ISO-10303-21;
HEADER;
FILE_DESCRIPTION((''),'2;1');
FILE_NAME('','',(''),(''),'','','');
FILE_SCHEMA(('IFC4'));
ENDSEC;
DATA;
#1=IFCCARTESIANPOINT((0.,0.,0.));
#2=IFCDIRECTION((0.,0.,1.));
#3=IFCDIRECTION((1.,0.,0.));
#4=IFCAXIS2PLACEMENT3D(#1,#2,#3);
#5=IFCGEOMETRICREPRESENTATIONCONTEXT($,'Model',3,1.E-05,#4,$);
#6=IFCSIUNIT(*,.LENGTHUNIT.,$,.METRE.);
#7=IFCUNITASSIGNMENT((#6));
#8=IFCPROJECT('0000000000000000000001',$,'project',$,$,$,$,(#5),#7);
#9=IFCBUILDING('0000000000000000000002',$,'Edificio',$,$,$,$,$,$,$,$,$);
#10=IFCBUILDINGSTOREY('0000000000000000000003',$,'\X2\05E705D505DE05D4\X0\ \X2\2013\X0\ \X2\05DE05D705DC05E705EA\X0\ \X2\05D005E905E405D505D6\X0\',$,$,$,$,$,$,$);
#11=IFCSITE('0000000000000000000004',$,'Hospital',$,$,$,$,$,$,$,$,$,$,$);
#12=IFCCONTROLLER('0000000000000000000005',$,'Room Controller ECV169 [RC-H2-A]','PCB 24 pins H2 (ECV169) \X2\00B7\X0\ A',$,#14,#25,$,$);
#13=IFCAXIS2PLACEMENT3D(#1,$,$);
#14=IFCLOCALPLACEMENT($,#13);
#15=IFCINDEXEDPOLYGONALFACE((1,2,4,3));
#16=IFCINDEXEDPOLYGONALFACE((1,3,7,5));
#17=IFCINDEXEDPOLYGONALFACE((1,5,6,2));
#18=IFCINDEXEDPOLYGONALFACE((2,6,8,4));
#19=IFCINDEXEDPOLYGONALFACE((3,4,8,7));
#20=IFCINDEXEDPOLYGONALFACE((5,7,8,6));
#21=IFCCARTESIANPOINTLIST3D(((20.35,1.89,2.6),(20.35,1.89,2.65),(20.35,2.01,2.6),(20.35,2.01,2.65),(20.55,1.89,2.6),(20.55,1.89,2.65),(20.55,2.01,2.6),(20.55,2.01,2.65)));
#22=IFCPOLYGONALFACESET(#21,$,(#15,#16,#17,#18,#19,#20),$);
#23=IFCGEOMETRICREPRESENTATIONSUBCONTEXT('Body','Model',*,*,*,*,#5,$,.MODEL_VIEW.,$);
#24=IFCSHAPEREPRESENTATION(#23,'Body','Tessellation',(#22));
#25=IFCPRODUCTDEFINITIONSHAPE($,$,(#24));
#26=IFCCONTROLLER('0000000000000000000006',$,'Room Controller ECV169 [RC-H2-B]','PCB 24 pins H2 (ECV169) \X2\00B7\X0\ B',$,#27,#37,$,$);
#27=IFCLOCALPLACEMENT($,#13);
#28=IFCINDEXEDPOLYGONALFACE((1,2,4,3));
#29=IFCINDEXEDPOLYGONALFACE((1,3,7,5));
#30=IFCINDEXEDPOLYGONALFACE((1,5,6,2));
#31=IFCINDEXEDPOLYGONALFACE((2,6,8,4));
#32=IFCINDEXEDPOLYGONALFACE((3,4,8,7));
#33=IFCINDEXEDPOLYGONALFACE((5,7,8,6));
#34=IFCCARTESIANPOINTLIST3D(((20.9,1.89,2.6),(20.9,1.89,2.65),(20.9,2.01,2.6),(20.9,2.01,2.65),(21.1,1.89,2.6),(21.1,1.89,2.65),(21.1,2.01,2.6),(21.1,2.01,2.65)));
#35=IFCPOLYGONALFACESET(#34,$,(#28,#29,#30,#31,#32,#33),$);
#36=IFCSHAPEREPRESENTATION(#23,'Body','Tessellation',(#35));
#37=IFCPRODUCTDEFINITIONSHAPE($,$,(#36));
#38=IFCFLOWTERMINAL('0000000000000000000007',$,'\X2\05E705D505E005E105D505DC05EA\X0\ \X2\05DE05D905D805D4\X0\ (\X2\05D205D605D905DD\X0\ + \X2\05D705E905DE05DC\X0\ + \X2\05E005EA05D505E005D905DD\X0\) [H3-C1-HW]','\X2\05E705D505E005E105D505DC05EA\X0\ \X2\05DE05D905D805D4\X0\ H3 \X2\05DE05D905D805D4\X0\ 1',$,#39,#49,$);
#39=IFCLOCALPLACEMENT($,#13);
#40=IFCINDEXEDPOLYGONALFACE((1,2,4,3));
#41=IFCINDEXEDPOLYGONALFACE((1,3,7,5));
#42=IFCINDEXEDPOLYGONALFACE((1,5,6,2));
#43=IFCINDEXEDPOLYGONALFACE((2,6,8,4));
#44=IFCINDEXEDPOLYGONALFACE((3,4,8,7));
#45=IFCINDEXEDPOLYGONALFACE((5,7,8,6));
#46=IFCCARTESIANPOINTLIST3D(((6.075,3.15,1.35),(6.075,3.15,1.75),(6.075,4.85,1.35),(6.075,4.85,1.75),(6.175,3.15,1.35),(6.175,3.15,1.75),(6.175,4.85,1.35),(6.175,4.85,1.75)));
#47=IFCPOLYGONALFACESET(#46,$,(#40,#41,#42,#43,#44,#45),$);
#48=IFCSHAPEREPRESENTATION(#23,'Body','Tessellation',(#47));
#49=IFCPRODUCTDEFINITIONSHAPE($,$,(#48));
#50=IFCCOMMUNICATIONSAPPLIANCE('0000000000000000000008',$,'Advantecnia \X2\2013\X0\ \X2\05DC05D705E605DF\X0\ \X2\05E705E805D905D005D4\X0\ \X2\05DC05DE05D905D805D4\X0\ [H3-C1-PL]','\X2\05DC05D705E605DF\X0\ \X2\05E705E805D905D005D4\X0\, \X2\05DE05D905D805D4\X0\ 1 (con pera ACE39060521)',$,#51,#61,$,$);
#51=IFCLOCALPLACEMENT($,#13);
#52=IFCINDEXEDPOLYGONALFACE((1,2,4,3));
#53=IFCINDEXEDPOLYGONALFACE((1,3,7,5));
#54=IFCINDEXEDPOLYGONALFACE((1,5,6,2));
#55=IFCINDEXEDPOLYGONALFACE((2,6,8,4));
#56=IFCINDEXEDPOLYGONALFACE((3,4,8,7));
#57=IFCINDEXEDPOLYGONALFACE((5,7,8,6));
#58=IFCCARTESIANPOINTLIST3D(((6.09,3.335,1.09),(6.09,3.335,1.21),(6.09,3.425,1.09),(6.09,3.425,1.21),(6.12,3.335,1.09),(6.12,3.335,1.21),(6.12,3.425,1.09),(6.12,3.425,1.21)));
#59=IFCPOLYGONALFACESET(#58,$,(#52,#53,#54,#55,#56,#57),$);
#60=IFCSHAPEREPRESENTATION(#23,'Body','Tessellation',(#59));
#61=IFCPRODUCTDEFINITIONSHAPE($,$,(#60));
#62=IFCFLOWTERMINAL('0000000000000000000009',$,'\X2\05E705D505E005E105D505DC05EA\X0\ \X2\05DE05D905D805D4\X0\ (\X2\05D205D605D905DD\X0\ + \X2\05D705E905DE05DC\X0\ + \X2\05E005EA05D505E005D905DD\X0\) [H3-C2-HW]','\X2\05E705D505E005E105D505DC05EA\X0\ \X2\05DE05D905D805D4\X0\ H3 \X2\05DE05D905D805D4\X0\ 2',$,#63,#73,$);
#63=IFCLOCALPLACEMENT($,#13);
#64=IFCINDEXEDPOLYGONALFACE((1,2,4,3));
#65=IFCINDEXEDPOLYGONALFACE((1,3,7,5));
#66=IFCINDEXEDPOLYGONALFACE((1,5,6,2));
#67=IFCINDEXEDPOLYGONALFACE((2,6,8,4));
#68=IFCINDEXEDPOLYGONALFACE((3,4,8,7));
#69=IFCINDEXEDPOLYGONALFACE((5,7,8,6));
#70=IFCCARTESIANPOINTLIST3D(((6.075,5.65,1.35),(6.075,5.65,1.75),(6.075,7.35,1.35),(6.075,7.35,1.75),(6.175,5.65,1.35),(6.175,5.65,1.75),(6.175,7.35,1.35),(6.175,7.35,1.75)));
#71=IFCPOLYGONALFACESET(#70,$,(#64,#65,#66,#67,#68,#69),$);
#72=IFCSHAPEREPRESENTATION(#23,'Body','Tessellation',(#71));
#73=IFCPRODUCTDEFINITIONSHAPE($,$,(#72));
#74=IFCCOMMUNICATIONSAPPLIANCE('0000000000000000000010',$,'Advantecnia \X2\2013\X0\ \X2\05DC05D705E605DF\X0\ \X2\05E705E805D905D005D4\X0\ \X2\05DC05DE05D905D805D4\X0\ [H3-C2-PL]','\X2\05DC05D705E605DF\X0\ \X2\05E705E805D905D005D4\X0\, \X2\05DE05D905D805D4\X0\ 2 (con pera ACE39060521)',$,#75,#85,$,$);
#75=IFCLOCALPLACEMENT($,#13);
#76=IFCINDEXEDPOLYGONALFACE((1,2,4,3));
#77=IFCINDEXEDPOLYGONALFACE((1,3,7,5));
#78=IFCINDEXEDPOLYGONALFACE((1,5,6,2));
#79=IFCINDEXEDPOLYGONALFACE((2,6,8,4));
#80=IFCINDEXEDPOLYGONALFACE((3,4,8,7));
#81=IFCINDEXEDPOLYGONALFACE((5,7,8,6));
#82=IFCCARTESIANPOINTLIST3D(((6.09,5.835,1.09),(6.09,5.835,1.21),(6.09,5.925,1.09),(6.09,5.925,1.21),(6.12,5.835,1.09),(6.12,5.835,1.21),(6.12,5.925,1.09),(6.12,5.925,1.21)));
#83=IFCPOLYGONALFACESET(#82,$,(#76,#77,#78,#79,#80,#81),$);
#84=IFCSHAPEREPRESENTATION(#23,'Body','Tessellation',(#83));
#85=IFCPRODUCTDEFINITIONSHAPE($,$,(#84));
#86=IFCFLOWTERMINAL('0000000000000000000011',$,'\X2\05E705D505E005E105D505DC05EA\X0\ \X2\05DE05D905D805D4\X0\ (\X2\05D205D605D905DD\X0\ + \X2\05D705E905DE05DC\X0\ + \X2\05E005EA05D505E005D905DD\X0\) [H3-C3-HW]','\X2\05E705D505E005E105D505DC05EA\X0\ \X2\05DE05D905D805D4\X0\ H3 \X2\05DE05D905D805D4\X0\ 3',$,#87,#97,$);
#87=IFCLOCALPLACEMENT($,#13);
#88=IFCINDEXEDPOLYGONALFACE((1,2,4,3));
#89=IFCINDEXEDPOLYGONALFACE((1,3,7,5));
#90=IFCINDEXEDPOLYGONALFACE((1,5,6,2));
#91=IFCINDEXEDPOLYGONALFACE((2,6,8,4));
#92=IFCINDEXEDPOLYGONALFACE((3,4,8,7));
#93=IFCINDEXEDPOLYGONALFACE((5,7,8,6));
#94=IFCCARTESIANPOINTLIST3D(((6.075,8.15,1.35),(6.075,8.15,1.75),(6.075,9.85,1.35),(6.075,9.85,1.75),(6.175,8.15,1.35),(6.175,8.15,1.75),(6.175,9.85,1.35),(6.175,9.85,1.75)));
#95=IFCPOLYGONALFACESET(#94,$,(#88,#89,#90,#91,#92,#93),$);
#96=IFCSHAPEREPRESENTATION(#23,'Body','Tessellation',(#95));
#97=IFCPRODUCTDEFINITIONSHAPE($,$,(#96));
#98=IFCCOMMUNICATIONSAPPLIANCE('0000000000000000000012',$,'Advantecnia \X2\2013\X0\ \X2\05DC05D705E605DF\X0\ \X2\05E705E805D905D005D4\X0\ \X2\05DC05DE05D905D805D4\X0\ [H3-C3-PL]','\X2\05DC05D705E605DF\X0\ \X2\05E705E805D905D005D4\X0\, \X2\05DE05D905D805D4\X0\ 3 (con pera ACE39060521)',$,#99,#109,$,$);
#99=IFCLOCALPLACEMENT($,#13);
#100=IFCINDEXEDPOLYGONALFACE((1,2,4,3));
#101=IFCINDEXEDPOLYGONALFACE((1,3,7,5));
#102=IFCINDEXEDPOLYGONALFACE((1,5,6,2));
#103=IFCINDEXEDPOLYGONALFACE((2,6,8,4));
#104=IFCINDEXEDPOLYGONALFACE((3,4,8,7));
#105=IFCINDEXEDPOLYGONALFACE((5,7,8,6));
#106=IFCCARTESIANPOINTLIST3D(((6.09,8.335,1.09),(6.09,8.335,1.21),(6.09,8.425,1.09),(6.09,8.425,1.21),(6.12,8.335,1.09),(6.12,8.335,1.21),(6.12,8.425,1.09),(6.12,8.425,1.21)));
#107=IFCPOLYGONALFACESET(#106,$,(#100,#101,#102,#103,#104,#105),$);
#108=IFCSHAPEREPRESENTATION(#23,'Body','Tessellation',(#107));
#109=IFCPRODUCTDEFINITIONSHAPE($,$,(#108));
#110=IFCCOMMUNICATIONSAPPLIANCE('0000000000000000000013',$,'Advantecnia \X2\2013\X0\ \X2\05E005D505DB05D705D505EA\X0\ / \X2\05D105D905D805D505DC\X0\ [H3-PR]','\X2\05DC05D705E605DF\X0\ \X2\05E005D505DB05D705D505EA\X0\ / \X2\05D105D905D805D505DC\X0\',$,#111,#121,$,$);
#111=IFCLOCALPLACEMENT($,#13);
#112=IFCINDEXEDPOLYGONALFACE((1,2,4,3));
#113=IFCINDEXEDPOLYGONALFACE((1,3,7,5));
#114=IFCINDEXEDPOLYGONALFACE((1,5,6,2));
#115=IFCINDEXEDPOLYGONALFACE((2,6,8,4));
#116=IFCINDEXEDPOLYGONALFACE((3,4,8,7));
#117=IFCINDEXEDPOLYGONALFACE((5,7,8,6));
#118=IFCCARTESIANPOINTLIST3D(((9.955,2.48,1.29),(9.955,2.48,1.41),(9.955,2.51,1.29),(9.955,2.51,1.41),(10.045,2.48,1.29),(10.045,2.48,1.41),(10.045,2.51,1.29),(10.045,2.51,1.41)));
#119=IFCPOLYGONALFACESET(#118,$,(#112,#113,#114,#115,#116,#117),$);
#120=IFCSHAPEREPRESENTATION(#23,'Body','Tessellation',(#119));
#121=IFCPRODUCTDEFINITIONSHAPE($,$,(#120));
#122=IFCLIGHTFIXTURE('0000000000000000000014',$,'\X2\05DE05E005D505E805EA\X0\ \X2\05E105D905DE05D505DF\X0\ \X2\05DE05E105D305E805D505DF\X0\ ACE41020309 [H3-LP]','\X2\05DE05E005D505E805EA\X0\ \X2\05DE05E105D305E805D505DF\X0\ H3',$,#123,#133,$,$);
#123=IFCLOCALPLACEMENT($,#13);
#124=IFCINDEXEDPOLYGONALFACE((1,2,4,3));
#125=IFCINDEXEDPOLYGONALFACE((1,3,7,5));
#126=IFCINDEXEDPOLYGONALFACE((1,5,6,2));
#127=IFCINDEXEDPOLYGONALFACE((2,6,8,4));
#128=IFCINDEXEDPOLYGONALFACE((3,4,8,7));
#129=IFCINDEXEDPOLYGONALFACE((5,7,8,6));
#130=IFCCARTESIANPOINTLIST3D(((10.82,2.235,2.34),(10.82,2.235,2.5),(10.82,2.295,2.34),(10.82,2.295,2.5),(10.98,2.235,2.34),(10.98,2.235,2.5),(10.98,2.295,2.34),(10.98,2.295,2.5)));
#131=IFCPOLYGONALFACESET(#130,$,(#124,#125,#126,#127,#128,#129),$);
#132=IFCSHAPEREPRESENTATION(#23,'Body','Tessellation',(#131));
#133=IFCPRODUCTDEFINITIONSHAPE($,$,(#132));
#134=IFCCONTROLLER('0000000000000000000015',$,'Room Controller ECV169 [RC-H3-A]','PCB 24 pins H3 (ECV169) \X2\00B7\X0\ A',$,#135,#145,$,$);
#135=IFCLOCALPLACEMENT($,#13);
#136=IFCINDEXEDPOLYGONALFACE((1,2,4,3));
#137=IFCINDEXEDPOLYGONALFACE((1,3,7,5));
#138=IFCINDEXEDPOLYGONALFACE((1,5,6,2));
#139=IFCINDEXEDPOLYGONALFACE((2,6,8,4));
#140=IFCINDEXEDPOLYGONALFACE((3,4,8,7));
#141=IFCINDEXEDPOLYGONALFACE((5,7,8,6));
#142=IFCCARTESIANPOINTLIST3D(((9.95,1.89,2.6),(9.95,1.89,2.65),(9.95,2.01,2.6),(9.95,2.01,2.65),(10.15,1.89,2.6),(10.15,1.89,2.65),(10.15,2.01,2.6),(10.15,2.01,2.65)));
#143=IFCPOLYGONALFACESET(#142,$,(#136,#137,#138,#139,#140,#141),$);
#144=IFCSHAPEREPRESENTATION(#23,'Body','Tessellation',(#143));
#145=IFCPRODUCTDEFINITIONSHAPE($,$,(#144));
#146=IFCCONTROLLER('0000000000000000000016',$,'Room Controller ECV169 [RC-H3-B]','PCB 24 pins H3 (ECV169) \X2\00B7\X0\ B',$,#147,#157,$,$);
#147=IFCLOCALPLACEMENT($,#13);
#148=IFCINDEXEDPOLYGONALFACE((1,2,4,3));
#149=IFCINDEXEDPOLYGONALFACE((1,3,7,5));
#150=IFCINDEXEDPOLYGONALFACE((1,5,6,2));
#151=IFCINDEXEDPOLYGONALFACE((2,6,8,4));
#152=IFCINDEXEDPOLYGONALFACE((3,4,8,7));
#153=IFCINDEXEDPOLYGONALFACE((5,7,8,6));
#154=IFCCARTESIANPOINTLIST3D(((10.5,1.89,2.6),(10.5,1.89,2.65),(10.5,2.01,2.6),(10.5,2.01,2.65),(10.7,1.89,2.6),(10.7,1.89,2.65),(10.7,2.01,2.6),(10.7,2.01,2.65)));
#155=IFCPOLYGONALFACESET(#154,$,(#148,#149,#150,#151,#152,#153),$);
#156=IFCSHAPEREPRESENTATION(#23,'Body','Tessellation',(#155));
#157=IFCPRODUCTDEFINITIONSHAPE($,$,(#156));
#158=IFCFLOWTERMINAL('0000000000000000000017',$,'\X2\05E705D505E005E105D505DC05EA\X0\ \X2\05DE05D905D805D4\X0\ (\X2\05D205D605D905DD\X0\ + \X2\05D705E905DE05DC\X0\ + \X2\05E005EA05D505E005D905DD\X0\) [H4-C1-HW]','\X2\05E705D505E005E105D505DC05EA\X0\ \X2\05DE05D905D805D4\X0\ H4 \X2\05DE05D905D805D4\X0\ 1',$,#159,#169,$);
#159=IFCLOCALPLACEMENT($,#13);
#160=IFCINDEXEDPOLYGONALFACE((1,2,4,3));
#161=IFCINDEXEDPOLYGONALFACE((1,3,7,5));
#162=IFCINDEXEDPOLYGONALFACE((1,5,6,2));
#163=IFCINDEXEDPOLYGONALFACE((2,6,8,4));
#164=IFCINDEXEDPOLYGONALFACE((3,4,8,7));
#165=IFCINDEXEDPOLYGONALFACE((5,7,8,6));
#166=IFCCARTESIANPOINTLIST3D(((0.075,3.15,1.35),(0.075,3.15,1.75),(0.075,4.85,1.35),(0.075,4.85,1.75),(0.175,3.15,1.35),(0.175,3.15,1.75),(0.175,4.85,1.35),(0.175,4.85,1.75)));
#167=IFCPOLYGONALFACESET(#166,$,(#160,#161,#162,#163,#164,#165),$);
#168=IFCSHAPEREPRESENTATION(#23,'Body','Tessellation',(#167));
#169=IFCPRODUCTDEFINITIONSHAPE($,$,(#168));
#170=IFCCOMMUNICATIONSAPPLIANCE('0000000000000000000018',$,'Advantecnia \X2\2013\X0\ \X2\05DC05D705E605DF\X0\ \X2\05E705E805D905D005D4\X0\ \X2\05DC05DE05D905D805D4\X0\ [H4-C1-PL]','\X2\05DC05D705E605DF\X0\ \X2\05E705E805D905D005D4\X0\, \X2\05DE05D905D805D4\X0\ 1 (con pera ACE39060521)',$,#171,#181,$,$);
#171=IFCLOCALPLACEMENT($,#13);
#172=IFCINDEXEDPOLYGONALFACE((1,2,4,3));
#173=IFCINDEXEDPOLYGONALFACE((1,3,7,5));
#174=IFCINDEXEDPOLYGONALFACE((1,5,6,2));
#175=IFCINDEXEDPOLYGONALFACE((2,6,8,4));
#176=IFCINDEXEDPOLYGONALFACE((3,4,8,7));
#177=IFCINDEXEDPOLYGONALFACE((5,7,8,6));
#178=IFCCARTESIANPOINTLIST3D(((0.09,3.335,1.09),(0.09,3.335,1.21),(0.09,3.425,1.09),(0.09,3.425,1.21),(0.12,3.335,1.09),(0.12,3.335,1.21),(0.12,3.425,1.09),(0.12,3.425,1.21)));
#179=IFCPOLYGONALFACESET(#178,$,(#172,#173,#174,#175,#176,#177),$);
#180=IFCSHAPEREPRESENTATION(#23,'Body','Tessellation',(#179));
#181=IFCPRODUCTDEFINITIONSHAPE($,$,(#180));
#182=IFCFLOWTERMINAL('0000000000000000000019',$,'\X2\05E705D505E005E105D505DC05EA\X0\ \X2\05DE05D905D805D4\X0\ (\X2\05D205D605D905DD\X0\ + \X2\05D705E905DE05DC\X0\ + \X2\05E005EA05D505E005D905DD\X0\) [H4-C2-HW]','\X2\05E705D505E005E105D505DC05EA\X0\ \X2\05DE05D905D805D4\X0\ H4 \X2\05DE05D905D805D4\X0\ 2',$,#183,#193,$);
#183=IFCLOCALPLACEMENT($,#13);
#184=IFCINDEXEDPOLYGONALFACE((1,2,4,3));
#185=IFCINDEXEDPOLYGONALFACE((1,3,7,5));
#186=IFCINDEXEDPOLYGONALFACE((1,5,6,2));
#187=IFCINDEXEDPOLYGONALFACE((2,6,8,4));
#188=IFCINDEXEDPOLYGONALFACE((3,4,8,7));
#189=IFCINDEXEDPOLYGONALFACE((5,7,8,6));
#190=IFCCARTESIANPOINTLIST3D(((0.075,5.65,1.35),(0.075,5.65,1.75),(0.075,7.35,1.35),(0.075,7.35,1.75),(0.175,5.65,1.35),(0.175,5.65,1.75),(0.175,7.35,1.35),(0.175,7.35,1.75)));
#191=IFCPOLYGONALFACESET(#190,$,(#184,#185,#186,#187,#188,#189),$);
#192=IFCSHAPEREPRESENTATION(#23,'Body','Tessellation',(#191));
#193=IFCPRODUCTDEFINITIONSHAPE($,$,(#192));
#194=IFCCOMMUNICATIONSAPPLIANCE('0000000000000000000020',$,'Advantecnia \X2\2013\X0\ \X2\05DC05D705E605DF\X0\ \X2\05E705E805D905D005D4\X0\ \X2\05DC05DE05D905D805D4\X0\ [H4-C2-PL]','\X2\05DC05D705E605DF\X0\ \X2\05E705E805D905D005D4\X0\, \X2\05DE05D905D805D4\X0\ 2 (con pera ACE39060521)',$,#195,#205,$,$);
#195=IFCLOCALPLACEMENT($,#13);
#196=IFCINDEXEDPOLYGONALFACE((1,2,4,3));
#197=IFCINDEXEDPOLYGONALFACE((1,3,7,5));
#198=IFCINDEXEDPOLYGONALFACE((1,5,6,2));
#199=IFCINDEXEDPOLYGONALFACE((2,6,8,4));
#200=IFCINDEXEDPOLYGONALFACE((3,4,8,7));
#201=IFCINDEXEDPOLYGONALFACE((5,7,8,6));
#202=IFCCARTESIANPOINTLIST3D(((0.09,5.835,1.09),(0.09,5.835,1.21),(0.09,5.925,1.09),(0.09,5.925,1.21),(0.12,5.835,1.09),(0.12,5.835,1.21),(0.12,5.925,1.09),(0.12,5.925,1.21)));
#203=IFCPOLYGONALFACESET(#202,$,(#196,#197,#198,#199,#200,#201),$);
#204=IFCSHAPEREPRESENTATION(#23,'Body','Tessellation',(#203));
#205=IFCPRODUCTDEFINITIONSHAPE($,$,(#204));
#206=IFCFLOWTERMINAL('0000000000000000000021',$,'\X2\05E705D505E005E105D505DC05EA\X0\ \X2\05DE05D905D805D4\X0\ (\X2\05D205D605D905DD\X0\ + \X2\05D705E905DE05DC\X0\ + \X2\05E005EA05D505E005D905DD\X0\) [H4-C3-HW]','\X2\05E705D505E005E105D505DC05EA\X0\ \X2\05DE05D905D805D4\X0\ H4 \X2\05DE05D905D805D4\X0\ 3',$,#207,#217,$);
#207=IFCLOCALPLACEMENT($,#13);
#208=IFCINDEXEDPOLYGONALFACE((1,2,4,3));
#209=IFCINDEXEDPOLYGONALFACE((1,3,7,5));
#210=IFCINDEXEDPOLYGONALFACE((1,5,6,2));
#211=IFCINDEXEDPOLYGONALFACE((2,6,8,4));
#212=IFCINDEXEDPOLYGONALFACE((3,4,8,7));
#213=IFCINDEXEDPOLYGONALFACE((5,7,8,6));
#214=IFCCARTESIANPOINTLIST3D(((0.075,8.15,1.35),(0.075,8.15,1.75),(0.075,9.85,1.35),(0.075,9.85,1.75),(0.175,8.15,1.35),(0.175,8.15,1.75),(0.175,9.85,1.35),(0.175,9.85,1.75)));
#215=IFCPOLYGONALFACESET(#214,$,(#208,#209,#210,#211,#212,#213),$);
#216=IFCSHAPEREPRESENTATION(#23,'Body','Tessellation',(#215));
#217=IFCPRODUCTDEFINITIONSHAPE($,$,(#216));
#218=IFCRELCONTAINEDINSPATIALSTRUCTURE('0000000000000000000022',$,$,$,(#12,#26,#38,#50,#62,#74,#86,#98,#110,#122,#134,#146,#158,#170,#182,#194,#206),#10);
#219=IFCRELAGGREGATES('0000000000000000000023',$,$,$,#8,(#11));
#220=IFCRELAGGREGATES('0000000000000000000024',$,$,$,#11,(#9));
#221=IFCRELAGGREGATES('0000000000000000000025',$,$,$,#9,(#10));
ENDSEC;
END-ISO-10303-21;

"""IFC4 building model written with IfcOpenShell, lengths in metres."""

from ifc_helpers import new_model, si_unit, frame, origin_with_axes, context, subcontext, project, spatial, line, indexed_curve, outline, extrude, element, save


model = new_model("IFC4")

# Units and contexts
model_context = context("Model", 3, precision=1e-05, world=origin_with_axes())
body_context = subcontext(model_context, "Body", "Model", "MODEL_VIEW")
ifc_project = project(units=[si_unit("LENGTHUNIT", "METRE")], contexts=[model_context])

# Site, building, storey
site = spatial("IfcSite", under=ifc_project, Name="Hospital")
building = spatial("IfcBuilding", under=site, Name="Edificio")
storey = spatial("IfcBuildingStorey", under=building, Name="קומה – מחלקת אשפוז")

# Controllers
element("IfcController", 1, inside=storey, Name="Room Controller ECV169 [RC-H2-A]", Description="PCB 24 pins H2 (ECV169) · A", context=body_context, shape_type="SweptSolid", body=[
    extrude(outline(indexed_curve([(0.0, 0.0), (0.2, 0.0), (0.2, 0.12), (0.0, 0.12)], segments=[line(1, 2, 3, 4, 1)])), frame((20.35, 1.89, 2.6), z_axis=(0.0, 0.0, 1.0), x_axis=(1.0, 0.0, 0.0)), (0.0, 0.0, 1.0), 0.05),
])
element("IfcController", 2, inside=storey, Name="Room Controller ECV169 [RC-H2-B]", Description="PCB 24 pins H2 (ECV169) · B", context=body_context, shape_type="SweptSolid", body=[
    extrude(outline(indexed_curve([(0.0, 0.0), (0.2, 0.0), (0.2, 0.12), (0.0, 0.12)], segments=[line(1, 2, 3, 4, 1)])), frame((20.9, 1.89, 2.6), z_axis=(0.0, 0.0, 1.0), x_axis=(1.0, 0.0, 0.0)), (0.0, 0.0, 1.0), 0.05),
])

# Flow terminal
element("IfcFlowTerminal", 3, inside=storey, Name="קונסולת מיטה (גזים + חשמל + נתונים) [H3-C1-HW]", Description="קונסולת מיטה H3 מיטה 1", context=body_context, shape_type="SweptSolid", body=[
    extrude(outline(indexed_curve([(0.0, 0.0), (0.1, 0.0), (0.1, 1.7), (0.0, 1.7)], segments=[line(1, 2, 3, 4, 1)])), frame((6.075, 3.15, 1.35), z_axis=(0.0, 0.0, 1.0), x_axis=(1.0, 0.0, 0.0)), (0.0, 0.0, 1.0), 0.4),
])

# Communications appliance
element("IfcCommunicationsAppliance", 4, inside=storey, Name="Advantecnia – לחצן קריאה למיטה [H3-C1-PL]", Description="לחצן קריאה, מיטה 1 (con pera ACE39060521)", context=body_context, shape_type="SweptSolid", body=[
    extrude(outline(indexed_curve([(0.0, 0.0), (0.03, 0.0), (0.03, 0.09), (0.0, 0.09)], segments=[line(1, 2, 3, 4, 1)])), frame((6.09, 3.335, 1.09), z_axis=(0.0, 0.0, 1.0), x_axis=(1.0, 0.0, 0.0)), (0.0, 0.0, 1.0), 0.12),
])

# Flow terminal
element("IfcFlowTerminal", 5, inside=storey, Name="קונסולת מיטה (גזים + חשמל + נתונים) [H3-C2-HW]", Description="קונסולת מיטה H3 מיטה 2", context=body_context, shape_type="SweptSolid", body=[
    extrude(outline(indexed_curve([(0.0, 0.0), (0.1, 0.0), (0.1, 1.7), (0.0, 1.7)], segments=[line(1, 2, 3, 4, 1)])), frame((6.075, 5.65, 1.35), z_axis=(0.0, 0.0, 1.0), x_axis=(1.0, 0.0, 0.0)), (0.0, 0.0, 1.0), 0.4),
])

# Communications appliance
element("IfcCommunicationsAppliance", 6, inside=storey, Name="Advantecnia – לחצן קריאה למיטה [H3-C2-PL]", Description="לחצן קריאה, מיטה 2 (con pera ACE39060521)", context=body_context, shape_type="SweptSolid", body=[
    extrude(outline(indexed_curve([(0.0, 0.0), (0.03, 0.0), (0.03, 0.09), (0.0, 0.09)], segments=[line(1, 2, 3, 4, 1)])), frame((6.09, 5.835, 1.09), z_axis=(0.0, 0.0, 1.0), x_axis=(1.0, 0.0, 0.0)), (0.0, 0.0, 1.0), 0.12),
])

# Flow terminal
element("IfcFlowTerminal", 7, inside=storey, Name="קונסולת מיטה (גזים + חשמל + נתונים) [H3-C3-HW]", Description="קונסולת מיטה H3 מיטה 3", context=body_context, shape_type="SweptSolid", body=[
    extrude(outline(indexed_curve([(0.0, 0.0), (0.1, 0.0), (0.1, 1.7), (0.0, 1.7)], segments=[line(1, 2, 3, 4, 1)])), frame((6.075, 8.15, 1.35), z_axis=(0.0, 0.0, 1.0), x_axis=(1.0, 0.0, 0.0)), (0.0, 0.0, 1.0), 0.4),
])

# Communications appliances
element("IfcCommunicationsAppliance", 8, inside=storey, Name="Advantecnia – לחצן קריאה למיטה [H3-C3-PL]", Description="לחצן קריאה, מיטה 3 (con pera ACE39060521)", context=body_context, shape_type="SweptSolid", body=[
    extrude(outline(indexed_curve([(0.0, 0.0), (0.03, 0.0), (0.03, 0.09), (0.0, 0.09)], segments=[line(1, 2, 3, 4, 1)])), frame((6.09, 8.335, 1.09), z_axis=(0.0, 0.0, 1.0), x_axis=(1.0, 0.0, 0.0)), (0.0, 0.0, 1.0), 0.12),
])
element("IfcCommunicationsAppliance", 9, inside=storey, Name="Advantecnia – נוכחות / ביטול [H3-PR]", Description="לחצן נוכחות / ביטול", context=body_context, shape_type="SweptSolid", body=[
    extrude(outline(indexed_curve([(0.0, 0.0), (0.09, 0.0), (0.09, 0.03), (0.0, 0.03)], segments=[line(1, 2, 3, 4, 1)])), frame((9.955, 2.48, 1.29), z_axis=(0.0, 0.0, 1.0), x_axis=(1.0, 0.0, 0.0)), (0.0, 0.0, 1.0), 0.12),
])

# Light fixture
element("IfcLightFixture", 10, inside=storey, Name="מנורת סימון מסדרון ACE41020309 [H3-LP]", Description="מנורת מסדרון H3", context=body_context, shape_type="SweptSolid", body=[
    extrude(outline(indexed_curve([(0.0, 0.0), (0.16, 0.0), (0.16, 0.06), (0.0, 0.06)], segments=[line(1, 2, 3, 4, 1)])), frame((10.82, 2.235, 2.34), z_axis=(0.0, 0.0, 1.0), x_axis=(1.0, 0.0, 0.0)), (0.0, 0.0, 1.0), 0.16),
])

# Controllers
element("IfcController", 11, inside=storey, Name="Room Controller ECV169 [RC-H3-A]", Description="PCB 24 pins H3 (ECV169) · A", context=body_context, shape_type="SweptSolid", body=[
    extrude(outline(indexed_curve([(0.0, 0.0), (0.2, 0.0), (0.2, 0.12), (0.0, 0.12)], segments=[line(1, 2, 3, 4, 1)])), frame((9.95, 1.89, 2.6), z_axis=(0.0, 0.0, 1.0), x_axis=(1.0, 0.0, 0.0)), (0.0, 0.0, 1.0), 0.05),
])
element("IfcController", 12, inside=storey, Name="Room Controller ECV169 [RC-H3-B]", Description="PCB 24 pins H3 (ECV169) · B", context=body_context, shape_type="SweptSolid", body=[
    extrude(outline(indexed_curve([(0.0, 0.0), (0.2, 0.0), (0.2, 0.12), (0.0, 0.12)], segments=[line(1, 2, 3, 4, 1)])), frame((10.5, 1.89, 2.6), z_axis=(0.0, 0.0, 1.0), x_axis=(1.0, 0.0, 0.0)), (0.0, 0.0, 1.0), 0.05),
])

# Flow terminal
element("IfcFlowTerminal", 13, inside=storey, Name="קונסולת מיטה (גזים + חשמל + נתונים) [H4-C1-HW]", Description="קונסולת מיטה H4 מיטה 1", context=body_context, shape_type="SweptSolid", body=[
    extrude(outline(indexed_curve([(0.0, 0.0), (0.1, 0.0), (0.1, 1.7), (0.0, 1.7)], segments=[line(1, 2, 3, 4, 1)])), frame((0.075, 3.15, 1.35), z_axis=(0.0, 0.0, 1.0), x_axis=(1.0, 0.0, 0.0)), (0.0, 0.0, 1.0), 0.4),
])

# Communications appliance
element("IfcCommunicationsAppliance", 14, inside=storey, Name="Advantecnia – לחצן קריאה למיטה [H4-C1-PL]", Description="לחצן קריאה, מיטה 1 (con pera ACE39060521)", context=body_context, shape_type="SweptSolid", body=[
    extrude(outline(indexed_curve([(0.0, 0.0), (0.03, 0.0), (0.03, 0.09), (0.0, 0.09)], segments=[line(1, 2, 3, 4, 1)])), frame((0.09, 3.335, 1.09), z_axis=(0.0, 0.0, 1.0), x_axis=(1.0, 0.0, 0.0)), (0.0, 0.0, 1.0), 0.12),
])

# Flow terminal
element("IfcFlowTerminal", 15, inside=storey, Name="קונסולת מיטה (גזים + חשמל + נתונים) [H4-C2-HW]", Description="קונסולת מיטה H4 מיטה 2", context=body_context, shape_type="SweptSolid", body=[
    extrude(outline(indexed_curve([(0.0, 0.0), (0.1, 0.0), (0.1, 1.7), (0.0, 1.7)], segments=[line(1, 2, 3, 4, 1)])), frame((0.075, 5.65, 1.35), z_axis=(0.0, 0.0, 1.0), x_axis=(1.0, 0.0, 0.0)), (0.0, 0.0, 1.0), 0.4),
])

# Communications appliance
element("IfcCommunicationsAppliance", 16, inside=storey, Name="Advantecnia – לחצן קריאה למיטה [H4-C2-PL]", Description="לחצן קריאה, מיטה 2 (con pera ACE39060521)", context=body_context, shape_type="SweptSolid", body=[
    extrude(outline(indexed_curve([(0.0, 0.0), (0.03, 0.0), (0.03, 0.09), (0.0, 0.09)], segments=[line(1, 2, 3, 4, 1)])), frame((0.09, 5.835, 1.09), z_axis=(0.0, 0.0, 1.0), x_axis=(1.0, 0.0, 0.0)), (0.0, 0.0, 1.0), 0.12),
])

# Flow terminal
element("IfcFlowTerminal", 17, inside=storey, Name="קונסולת מיטה (גזים + חשמל + נתונים) [H4-C3-HW]", Description="קונסולת מיטה H4 מיטה 3", context=body_context, shape_type="SweptSolid", body=[
    extrude(outline(indexed_curve([(0.0, 0.0), (0.1, 0.0), (0.1, 1.7), (0.0, 1.7)], segments=[line(1, 2, 3, 4, 1)])), frame((0.075, 8.15, 1.35), z_axis=(0.0, 0.0, 1.0), x_axis=(1.0, 0.0, 0.0)), (0.0, 0.0, 1.0), 0.4),
])

save(model, "model.ifc")
